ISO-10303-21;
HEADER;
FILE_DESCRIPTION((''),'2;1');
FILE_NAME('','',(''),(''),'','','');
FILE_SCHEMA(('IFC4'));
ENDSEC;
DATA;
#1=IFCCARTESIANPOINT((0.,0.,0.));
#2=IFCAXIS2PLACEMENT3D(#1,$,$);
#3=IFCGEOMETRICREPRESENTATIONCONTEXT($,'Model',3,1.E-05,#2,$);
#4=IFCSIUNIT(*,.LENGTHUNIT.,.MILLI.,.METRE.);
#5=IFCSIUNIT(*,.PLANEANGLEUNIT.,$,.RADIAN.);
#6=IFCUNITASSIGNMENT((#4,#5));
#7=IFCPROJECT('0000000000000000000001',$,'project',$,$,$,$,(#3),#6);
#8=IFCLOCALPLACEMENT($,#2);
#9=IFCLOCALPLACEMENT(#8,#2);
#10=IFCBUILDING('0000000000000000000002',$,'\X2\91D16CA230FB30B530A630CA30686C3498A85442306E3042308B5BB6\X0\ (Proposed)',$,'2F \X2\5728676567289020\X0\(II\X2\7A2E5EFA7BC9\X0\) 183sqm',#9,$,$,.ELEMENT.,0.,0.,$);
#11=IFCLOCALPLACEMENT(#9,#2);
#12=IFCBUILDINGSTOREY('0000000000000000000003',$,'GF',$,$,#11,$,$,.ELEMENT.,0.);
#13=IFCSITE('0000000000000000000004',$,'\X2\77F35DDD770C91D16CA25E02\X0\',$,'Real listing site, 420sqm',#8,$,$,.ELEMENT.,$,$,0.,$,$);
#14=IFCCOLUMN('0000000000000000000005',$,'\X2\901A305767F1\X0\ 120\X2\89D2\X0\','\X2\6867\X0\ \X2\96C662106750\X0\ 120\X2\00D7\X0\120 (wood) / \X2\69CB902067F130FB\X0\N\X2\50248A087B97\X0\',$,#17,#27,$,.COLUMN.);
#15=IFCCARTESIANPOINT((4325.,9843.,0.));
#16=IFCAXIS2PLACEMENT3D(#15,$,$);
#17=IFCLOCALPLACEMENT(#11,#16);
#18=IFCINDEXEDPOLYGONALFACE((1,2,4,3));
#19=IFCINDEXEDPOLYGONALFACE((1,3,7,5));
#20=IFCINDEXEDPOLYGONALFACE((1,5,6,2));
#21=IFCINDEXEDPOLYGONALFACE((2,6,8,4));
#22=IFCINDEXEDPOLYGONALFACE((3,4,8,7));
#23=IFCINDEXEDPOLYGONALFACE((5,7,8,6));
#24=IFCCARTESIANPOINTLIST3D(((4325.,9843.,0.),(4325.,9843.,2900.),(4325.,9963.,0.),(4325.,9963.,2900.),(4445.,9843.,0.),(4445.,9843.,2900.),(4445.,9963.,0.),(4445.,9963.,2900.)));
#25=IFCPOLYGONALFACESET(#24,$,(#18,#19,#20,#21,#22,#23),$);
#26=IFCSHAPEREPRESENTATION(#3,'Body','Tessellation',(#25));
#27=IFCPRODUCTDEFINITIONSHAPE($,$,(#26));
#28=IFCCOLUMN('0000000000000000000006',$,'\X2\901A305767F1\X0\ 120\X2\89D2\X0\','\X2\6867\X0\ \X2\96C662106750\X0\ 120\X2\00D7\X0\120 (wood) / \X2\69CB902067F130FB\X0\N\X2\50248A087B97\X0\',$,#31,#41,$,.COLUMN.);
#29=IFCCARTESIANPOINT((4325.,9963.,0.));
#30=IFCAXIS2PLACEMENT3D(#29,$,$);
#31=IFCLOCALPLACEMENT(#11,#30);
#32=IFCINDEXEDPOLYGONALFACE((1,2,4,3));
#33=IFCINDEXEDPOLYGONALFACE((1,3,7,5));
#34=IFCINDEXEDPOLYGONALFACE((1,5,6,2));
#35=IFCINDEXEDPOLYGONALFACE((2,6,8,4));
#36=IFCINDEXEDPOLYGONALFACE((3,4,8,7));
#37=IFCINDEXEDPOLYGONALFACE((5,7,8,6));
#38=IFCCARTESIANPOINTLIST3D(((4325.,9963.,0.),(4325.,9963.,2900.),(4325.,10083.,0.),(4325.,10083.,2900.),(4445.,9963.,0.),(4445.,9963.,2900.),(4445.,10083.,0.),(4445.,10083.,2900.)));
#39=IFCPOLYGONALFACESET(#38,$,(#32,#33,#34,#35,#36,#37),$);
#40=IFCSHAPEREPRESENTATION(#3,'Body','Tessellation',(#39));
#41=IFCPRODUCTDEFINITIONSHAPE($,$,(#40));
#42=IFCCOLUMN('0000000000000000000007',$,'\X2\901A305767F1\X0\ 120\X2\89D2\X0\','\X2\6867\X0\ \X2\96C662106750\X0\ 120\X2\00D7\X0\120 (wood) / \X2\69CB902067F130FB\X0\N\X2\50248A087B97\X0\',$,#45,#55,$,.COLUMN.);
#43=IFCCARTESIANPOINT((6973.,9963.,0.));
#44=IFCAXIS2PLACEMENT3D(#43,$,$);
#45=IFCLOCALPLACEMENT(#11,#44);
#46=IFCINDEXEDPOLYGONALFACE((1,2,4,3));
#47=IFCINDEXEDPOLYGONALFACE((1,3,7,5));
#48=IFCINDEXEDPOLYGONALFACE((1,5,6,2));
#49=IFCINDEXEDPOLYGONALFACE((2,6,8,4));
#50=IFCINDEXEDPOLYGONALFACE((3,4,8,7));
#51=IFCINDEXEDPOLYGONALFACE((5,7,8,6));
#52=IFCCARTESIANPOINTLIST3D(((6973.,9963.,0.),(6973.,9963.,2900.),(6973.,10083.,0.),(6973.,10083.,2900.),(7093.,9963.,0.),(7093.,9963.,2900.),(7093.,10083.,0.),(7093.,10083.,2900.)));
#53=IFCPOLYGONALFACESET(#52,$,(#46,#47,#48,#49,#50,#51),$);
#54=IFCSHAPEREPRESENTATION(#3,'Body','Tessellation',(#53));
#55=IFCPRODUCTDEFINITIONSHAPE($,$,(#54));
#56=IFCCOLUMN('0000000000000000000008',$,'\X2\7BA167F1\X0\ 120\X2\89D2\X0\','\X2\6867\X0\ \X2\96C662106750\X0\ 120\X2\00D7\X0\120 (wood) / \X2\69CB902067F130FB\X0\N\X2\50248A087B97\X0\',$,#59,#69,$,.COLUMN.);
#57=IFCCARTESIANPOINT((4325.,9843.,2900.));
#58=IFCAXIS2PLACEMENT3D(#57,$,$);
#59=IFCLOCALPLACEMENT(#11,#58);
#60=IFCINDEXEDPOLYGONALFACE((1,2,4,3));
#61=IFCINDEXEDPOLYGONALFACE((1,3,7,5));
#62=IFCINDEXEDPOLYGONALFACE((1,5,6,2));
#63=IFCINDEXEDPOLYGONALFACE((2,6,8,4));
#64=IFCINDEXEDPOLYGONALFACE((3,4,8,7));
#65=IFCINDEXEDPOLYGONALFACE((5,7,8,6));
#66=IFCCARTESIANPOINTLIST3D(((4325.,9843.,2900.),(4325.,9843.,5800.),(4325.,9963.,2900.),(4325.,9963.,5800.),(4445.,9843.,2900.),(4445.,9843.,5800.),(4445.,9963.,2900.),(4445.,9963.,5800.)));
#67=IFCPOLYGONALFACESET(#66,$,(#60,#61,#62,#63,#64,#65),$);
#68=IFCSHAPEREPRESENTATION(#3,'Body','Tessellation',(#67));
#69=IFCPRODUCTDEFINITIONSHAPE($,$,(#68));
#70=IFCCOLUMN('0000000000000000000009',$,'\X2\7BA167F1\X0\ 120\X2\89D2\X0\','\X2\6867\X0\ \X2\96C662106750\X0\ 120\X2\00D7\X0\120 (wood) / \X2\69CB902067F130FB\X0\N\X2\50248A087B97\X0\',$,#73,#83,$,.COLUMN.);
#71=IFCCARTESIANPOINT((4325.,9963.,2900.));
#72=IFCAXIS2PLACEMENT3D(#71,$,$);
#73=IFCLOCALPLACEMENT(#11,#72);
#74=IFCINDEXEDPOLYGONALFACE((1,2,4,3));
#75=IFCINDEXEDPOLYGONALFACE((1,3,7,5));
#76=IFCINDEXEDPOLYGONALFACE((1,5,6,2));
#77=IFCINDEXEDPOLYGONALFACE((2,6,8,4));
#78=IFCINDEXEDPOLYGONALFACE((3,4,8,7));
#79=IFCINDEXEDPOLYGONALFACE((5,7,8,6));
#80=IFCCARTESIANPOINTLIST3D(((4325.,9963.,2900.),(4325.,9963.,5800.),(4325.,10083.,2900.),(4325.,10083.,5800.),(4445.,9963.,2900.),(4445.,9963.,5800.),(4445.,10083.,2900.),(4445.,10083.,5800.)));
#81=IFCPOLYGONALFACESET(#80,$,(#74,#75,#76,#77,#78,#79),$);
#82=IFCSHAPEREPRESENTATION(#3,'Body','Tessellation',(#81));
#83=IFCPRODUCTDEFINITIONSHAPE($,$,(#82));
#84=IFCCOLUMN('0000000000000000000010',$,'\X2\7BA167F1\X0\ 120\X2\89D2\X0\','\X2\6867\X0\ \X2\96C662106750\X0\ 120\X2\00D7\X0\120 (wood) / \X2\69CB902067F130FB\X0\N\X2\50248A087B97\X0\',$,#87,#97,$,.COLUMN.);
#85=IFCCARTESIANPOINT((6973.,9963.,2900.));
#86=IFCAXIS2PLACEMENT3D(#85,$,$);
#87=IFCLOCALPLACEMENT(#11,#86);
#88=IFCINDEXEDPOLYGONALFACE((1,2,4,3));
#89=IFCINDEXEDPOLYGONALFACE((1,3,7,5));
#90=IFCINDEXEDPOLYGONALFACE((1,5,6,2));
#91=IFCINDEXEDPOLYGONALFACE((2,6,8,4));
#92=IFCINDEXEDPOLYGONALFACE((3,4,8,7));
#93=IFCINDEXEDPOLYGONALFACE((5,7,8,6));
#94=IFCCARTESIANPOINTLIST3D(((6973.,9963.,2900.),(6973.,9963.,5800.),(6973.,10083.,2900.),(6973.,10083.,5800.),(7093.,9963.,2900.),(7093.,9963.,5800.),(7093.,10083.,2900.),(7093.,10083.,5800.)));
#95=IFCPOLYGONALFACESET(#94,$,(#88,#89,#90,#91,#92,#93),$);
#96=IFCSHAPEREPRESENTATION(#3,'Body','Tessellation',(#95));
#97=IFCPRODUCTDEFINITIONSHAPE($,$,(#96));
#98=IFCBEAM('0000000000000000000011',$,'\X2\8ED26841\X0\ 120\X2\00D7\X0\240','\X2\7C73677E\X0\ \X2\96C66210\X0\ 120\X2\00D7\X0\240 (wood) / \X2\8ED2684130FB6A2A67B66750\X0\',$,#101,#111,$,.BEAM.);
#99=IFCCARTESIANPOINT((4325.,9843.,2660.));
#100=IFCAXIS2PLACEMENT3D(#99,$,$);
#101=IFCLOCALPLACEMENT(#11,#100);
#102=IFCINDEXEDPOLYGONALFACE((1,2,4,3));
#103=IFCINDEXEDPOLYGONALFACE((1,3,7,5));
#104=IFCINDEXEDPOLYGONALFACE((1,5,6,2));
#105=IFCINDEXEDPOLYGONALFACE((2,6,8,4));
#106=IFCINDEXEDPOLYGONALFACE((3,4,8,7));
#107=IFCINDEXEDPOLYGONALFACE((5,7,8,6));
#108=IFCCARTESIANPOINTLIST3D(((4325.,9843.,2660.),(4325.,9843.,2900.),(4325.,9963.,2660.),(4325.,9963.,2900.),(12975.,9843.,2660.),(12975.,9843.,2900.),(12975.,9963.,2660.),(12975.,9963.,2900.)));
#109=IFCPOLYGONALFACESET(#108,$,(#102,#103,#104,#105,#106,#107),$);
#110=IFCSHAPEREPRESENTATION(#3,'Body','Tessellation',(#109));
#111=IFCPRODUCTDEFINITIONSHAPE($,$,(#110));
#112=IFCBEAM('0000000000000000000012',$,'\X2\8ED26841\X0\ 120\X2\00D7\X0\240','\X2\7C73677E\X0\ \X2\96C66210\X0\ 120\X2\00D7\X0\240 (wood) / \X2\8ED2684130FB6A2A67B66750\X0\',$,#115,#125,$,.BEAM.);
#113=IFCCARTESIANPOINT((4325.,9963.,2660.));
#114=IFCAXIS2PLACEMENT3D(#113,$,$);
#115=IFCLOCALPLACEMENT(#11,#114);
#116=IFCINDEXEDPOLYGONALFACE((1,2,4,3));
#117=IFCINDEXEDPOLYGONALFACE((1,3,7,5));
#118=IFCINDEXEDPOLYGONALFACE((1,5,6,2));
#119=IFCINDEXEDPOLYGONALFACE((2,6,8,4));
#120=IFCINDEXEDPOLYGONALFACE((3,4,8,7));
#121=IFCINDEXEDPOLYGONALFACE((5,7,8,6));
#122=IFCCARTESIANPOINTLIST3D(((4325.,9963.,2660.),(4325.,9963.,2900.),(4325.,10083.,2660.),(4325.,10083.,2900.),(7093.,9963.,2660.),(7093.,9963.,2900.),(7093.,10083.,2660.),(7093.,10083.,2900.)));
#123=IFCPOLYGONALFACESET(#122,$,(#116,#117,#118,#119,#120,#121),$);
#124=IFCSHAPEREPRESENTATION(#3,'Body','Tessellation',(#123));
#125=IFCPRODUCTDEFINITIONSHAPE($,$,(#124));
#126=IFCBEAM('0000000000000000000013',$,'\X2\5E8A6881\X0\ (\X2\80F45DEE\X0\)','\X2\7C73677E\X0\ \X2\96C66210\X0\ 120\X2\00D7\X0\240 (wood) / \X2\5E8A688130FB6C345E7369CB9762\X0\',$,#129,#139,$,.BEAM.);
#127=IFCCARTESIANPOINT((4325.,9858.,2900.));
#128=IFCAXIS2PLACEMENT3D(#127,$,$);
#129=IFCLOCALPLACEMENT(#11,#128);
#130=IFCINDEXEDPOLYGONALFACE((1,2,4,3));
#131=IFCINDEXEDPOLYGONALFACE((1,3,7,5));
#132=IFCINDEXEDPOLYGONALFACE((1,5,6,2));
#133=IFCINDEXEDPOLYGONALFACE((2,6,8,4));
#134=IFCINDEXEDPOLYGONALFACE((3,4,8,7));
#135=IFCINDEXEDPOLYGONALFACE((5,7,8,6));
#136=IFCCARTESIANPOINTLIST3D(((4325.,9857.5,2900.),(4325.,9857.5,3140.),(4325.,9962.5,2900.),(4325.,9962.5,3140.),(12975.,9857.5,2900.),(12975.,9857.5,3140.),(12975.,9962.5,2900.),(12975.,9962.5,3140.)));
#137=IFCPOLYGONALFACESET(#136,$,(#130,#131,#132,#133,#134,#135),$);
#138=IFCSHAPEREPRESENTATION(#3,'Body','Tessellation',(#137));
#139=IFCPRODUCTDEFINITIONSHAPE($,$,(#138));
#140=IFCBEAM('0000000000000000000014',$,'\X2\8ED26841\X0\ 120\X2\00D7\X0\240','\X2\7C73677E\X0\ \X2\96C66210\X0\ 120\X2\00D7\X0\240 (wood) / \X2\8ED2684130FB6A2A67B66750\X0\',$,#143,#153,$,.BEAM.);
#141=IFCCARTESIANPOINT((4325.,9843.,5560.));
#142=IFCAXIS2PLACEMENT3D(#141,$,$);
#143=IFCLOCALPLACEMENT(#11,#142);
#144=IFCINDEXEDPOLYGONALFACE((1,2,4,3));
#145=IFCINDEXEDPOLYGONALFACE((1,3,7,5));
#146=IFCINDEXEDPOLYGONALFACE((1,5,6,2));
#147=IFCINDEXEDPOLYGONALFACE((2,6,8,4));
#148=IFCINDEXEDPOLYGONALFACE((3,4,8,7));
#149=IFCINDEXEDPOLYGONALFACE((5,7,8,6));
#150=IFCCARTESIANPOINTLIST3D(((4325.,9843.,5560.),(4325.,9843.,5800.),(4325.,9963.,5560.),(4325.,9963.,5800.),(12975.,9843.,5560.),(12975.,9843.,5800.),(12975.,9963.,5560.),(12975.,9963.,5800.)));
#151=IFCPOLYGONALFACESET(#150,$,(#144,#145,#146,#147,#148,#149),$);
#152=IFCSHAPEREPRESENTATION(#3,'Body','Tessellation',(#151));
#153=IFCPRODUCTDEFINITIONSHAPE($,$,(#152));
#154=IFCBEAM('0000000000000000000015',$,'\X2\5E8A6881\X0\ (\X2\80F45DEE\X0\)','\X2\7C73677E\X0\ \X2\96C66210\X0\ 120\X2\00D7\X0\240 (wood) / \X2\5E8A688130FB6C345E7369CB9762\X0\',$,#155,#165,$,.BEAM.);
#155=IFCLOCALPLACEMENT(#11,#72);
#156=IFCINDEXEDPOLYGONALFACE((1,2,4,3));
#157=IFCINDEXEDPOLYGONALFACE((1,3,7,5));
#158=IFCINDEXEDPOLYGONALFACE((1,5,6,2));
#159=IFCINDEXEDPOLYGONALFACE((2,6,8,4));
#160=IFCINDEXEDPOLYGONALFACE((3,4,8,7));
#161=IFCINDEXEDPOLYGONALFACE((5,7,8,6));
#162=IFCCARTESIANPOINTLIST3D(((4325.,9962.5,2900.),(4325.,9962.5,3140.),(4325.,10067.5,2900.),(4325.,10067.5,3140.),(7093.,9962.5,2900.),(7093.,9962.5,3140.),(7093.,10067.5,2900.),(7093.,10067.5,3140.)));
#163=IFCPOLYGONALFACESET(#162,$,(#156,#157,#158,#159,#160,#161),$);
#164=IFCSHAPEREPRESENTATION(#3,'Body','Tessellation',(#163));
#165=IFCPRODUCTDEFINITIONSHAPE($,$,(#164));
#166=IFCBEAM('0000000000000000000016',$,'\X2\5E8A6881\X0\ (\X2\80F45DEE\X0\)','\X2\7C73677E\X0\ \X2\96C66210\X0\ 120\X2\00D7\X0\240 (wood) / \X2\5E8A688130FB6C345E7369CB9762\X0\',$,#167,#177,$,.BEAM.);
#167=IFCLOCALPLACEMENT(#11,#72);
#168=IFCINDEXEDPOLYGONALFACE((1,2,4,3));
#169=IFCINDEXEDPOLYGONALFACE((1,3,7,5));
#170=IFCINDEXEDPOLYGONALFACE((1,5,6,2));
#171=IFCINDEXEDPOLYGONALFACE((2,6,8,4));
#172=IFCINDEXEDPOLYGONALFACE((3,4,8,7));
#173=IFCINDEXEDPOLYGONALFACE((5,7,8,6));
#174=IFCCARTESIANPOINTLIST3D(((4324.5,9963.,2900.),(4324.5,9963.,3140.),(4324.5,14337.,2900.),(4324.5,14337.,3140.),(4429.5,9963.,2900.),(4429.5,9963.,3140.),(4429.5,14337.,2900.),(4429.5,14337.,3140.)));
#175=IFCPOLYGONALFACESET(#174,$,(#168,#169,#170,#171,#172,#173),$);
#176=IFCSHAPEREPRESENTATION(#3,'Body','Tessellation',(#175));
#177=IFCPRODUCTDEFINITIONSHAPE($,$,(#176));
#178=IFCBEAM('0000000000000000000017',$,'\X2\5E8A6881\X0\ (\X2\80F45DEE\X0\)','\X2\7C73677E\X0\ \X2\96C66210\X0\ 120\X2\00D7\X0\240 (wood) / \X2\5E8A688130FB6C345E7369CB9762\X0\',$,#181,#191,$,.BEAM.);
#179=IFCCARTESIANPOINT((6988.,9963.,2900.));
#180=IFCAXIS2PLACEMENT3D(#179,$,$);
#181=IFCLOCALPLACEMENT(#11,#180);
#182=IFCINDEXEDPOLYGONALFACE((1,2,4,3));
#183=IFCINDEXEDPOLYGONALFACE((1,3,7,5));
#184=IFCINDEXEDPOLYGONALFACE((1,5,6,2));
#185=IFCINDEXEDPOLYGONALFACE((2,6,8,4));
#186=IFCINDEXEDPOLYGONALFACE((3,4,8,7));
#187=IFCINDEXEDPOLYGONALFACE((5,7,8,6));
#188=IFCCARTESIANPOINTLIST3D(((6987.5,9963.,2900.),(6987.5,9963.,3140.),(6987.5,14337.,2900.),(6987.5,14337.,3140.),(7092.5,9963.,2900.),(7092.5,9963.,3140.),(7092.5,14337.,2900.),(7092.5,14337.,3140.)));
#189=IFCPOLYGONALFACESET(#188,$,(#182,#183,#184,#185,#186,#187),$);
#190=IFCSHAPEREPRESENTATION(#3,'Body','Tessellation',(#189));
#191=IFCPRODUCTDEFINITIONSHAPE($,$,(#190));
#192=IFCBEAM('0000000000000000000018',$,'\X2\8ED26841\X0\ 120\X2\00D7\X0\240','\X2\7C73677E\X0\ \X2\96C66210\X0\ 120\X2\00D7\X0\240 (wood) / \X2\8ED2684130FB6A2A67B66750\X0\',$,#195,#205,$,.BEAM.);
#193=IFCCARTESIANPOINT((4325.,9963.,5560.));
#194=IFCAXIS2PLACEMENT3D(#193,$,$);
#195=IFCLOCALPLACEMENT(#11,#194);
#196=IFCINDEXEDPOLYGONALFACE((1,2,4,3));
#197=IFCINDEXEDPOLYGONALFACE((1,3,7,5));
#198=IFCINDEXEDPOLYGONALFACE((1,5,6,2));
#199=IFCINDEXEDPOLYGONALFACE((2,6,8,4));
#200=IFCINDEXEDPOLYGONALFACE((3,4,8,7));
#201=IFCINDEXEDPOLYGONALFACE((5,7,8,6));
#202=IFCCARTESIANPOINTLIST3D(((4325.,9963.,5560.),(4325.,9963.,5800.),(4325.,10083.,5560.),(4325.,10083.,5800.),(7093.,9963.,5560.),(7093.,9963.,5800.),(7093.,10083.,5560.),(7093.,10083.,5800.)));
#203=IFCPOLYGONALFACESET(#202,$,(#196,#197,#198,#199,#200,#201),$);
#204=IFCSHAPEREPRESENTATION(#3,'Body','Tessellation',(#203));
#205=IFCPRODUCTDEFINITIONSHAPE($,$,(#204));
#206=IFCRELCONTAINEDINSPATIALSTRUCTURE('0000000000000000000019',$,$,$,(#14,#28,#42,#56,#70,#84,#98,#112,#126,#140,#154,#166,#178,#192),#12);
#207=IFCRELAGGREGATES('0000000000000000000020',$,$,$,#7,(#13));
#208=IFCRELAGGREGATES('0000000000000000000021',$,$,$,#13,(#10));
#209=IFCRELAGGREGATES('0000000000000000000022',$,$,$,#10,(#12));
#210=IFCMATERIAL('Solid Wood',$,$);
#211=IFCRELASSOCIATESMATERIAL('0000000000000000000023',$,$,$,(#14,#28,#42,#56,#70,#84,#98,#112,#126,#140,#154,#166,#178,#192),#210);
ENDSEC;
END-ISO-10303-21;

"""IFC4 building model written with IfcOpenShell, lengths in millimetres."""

from ifc_helpers import new_model, si_unit, frame, frame_2d, origin, place, context, project, spatial, rectangle, extrude, material, element, save


model = new_model("IFC4")

# Units and contexts
model_context = context("Model", 3, precision=1e-05, world=origin())
ifc_project = project(units=[si_unit("LENGTHUNIT", "METRE", prefix="MILLI"), si_unit("PLANEANGLEUNIT", "RADIAN")], contexts=[model_context])

# Site, building, storey
site_placement = place(None, origin())
site = spatial("IfcSite", under=ifc_project, at=site_placement, Name="石川県金沢市", ObjectType="Real listing site, 420sqm", CompositionType="ELEMENT", RefElevation=0.0)
building_placement = place(site_placement, origin())
building = spatial("IfcBuilding", under=site, at=building_placement, Name="金沢・サウナと水風呂のある家 (Proposed)", ObjectType="2F 在来木造(II種建築) 183sqm", CompositionType="ELEMENT", ElevationOfRefHeight=0.0, ElevationOfTerrain=0.0)
storey_placement = place(building_placement, origin())
storey = spatial("IfcBuildingStorey", under=building, at=storey_placement, Name="GF", CompositionType="ELEMENT", Elevation=0.0)

# Columns
ifc_material_1 = material(Name="Solid Wood")
column_1_placement = place(storey_placement, frame((4325.0, 9843.0, 0.0)))
element("IfcColumn", 1, at=column_1_placement, inside=storey, material=ifc_material_1, Name="通し柱 120角", Description="桧 集成材 120×120 (wood) / 構造柱・N値計算", PredefinedType="COLUMN", context=model_context, shape_type="SweptSolid", body=[
    extrude(rectangle(XDim=120.0, YDim=120.0, at=frame_2d((60.0, 60.0))), frame((4325.0, 9843.0, 0.0)), (0.0, 0.0, 1.0), 2900.0),
])
column_2_placement = place(storey_placement, frame((4325.0, 9963.0, 0.0)))
element("IfcColumn", 2, at=column_2_placement, inside=storey, material=ifc_material_1, Name="通し柱 120角", Description="桧 集成材 120×120 (wood) / 構造柱・N値計算", PredefinedType="COLUMN", context=model_context, shape_type="SweptSolid", body=[
    extrude(rectangle(XDim=120.0, YDim=120.0, at=frame_2d((60.0, 60.0))), frame((4325.0, 9963.0, 0.0)), (0.0, 0.0, 1.0), 2900.0),
])
column_3_placement = place(storey_placement, frame((6973.0, 9963.0, 0.0)))
element("IfcColumn", 3, at=column_3_placement, inside=storey, material=ifc_material_1, Name="通し柱 120角", Description="桧 集成材 120×120 (wood) / 構造柱・N値計算", PredefinedType="COLUMN", context=model_context, shape_type="SweptSolid", body=[
    extrude(rectangle(XDim=120.0, YDim=120.0, at=frame_2d((60.0, 60.0))), frame((6973.0, 9963.0, 0.0)), (0.0, 0.0, 1.0), 2900.0),
])
column_4_placement = place(storey_placement, frame((4325.0, 9843.0, 2900.0)))
element("IfcColumn", 4, at=column_4_placement, inside=storey, material=ifc_material_1, Name="管柱 120角", Description="桧 集成材 120×120 (wood) / 構造柱・N値計算", PredefinedType="COLUMN", context=model_context, shape_type="SweptSolid", body=[
    extrude(rectangle(XDim=120.0, YDim=120.0, at=frame_2d((60.0, 60.0))), frame((4325.0, 9843.0, 2900.0)), (0.0, 0.0, 1.0), 2900.0),
])
column_5_placement = place(storey_placement, frame((4325.0, 9963.0, 2900.0)))
element("IfcColumn", 5, at=column_5_placement, inside=storey, material=ifc_material_1, Name="管柱 120角", Description="桧 集成材 120×120 (wood) / 構造柱・N値計算", PredefinedType="COLUMN", context=model_context, shape_type="SweptSolid", body=[
    extrude(rectangle(XDim=120.0, YDim=120.0, at=frame_2d((60.0, 60.0))), frame((4325.0, 9963.0, 2900.0)), (0.0, 0.0, 1.0), 2900.0),
])
column_6_placement = place(storey_placement, frame((6973.0, 9963.0, 2900.0)))
element("IfcColumn", 6, at=column_6_placement, inside=storey, material=ifc_material_1, Name="管柱 120角", Description="桧 集成材 120×120 (wood) / 構造柱・N値計算", PredefinedType="COLUMN", context=model_context, shape_type="SweptSolid", body=[
    extrude(rectangle(XDim=120.0, YDim=120.0, at=frame_2d((60.0, 60.0))), frame((6973.0, 9963.0, 2900.0)), (0.0, 0.0, 1.0), 2900.0),
])

# Beams
beam_1_placement = place(storey_placement, frame((4325.0, 9843.0, 2660.0)))
element("IfcBeam", 7, at=beam_1_placement, inside=storey, material=ifc_material_1, Name="軒桁 120×240", Description="米松 集成 120×240 (wood) / 軒桁・横架材", PredefinedType="BEAM", context=model_context, shape_type="SweptSolid", body=[
    extrude(rectangle(XDim=8650.0, YDim=120.0, at=frame_2d((4325.0, 60.0))), frame((4325.0, 9843.0, 2660.0)), (0.0, 0.0, 1.0), 240.0),
])
beam_2_placement = place(storey_placement, frame((4325.0, 9963.0, 2660.0)))
element("IfcBeam", 8, at=beam_2_placement, inside=storey, material=ifc_material_1, Name="軒桁 120×240", Description="米松 集成 120×240 (wood) / 軒桁・横架材", PredefinedType="BEAM", context=model_context, shape_type="SweptSolid", body=[
    extrude(rectangle(XDim=2768.0, YDim=120.0, at=frame_2d((1384.0, 60.0))), frame((4325.0, 9963.0, 2660.0)), (0.0, 0.0, 1.0), 240.0),
])
beam_3_placement = place(storey_placement, frame((4325.0, 9858.0, 2900.0)))
element("IfcBeam", 9, at=beam_3_placement, inside=storey, material=ifc_material_1, Name="床梁 (胴差)", Description="米松 集成 120×240 (wood) / 床梁・水平構面", PredefinedType="BEAM", context=model_context, shape_type="SweptSolid", body=[
    extrude(rectangle(XDim=8650.0, YDim=105.0, at=frame_2d((4325.0, 52.0))), frame((4325.0, 9858.0, 2900.0)), (0.0, 0.0, 1.0), 240.0),
])
beam_4_placement = place(storey_placement, frame((4325.0, 9843.0, 5560.0)))
element("IfcBeam", 10, at=beam_4_placement, inside=storey, material=ifc_material_1, Name="軒桁 120×240", Description="米松 集成 120×240 (wood) / 軒桁・横架材", PredefinedType="BEAM", context=model_context, shape_type="SweptSolid", body=[
    extrude(rectangle(XDim=8650.0, YDim=120.0, at=frame_2d((4325.0, 60.0))), frame((4325.0, 9843.0, 5560.0)), (0.0, 0.0, 1.0), 240.0),
])
beam_5_placement = place(storey_placement, frame((4325.0, 9963.0, 2900.0)))
element("IfcBeam", 11, at=beam_5_placement, inside=storey, material=ifc_material_1, Name="床梁 (胴差)", Description="米松 集成 120×240 (wood) / 床梁・水平構面", PredefinedType="BEAM", context=model_context, shape_type="SweptSolid", body=[
    extrude(rectangle(XDim=2768.0, YDim=105.0, at=frame_2d((1384.0, 52.0))), frame((4325.0, 9963.0, 2900.0)), (0.0, 0.0, 1.0), 240.0),
])
beam_6_placement = place(storey_placement, frame((4325.0, 9963.0, 2900.0)))
element("IfcBeam", 12, at=beam_6_placement, inside=storey, material=ifc_material_1, Name="床梁 (胴差)", Description="米松 集成 120×240 (wood) / 床梁・水平構面", PredefinedType="BEAM", context=model_context, shape_type="SweptSolid", body=[
    extrude(rectangle(XDim=105.0, YDim=4374.0, at=frame_2d((52.0, 2187.0))), frame((4325.0, 9963.0, 2900.0)), (0.0, 0.0, 1.0), 240.0),
])
beam_7_placement = place(storey_placement, frame((6988.0, 9963.0, 2900.0)))
element("IfcBeam", 13, at=beam_7_placement, inside=storey, material=ifc_material_1, Name="床梁 (胴差)", Description="米松 集成 120×240 (wood) / 床梁・水平構面", PredefinedType="BEAM", context=model_context, shape_type="SweptSolid", body=[
    extrude(rectangle(XDim=105.0, YDim=4374.0, at=frame_2d((52.0, 2187.0))), frame((6988.0, 9963.0, 2900.0)), (0.0, 0.0, 1.0), 240.0),
])
beam_8_placement = place(storey_placement, frame((4325.0, 9963.0, 5560.0)))
element("IfcBeam", 14, at=beam_8_placement, inside=storey, material=ifc_material_1, Name="軒桁 120×240", Description="米松 集成 120×240 (wood) / 軒桁・横架材", PredefinedType="BEAM", context=model_context, shape_type="SweptSolid", body=[
    extrude(rectangle(XDim=2768.0, YDim=120.0, at=frame_2d((1384.0, 60.0))), frame((4325.0, 9963.0, 5560.0)), (0.0, 0.0, 1.0), 240.0),
])

save(model, "model.ifc")
